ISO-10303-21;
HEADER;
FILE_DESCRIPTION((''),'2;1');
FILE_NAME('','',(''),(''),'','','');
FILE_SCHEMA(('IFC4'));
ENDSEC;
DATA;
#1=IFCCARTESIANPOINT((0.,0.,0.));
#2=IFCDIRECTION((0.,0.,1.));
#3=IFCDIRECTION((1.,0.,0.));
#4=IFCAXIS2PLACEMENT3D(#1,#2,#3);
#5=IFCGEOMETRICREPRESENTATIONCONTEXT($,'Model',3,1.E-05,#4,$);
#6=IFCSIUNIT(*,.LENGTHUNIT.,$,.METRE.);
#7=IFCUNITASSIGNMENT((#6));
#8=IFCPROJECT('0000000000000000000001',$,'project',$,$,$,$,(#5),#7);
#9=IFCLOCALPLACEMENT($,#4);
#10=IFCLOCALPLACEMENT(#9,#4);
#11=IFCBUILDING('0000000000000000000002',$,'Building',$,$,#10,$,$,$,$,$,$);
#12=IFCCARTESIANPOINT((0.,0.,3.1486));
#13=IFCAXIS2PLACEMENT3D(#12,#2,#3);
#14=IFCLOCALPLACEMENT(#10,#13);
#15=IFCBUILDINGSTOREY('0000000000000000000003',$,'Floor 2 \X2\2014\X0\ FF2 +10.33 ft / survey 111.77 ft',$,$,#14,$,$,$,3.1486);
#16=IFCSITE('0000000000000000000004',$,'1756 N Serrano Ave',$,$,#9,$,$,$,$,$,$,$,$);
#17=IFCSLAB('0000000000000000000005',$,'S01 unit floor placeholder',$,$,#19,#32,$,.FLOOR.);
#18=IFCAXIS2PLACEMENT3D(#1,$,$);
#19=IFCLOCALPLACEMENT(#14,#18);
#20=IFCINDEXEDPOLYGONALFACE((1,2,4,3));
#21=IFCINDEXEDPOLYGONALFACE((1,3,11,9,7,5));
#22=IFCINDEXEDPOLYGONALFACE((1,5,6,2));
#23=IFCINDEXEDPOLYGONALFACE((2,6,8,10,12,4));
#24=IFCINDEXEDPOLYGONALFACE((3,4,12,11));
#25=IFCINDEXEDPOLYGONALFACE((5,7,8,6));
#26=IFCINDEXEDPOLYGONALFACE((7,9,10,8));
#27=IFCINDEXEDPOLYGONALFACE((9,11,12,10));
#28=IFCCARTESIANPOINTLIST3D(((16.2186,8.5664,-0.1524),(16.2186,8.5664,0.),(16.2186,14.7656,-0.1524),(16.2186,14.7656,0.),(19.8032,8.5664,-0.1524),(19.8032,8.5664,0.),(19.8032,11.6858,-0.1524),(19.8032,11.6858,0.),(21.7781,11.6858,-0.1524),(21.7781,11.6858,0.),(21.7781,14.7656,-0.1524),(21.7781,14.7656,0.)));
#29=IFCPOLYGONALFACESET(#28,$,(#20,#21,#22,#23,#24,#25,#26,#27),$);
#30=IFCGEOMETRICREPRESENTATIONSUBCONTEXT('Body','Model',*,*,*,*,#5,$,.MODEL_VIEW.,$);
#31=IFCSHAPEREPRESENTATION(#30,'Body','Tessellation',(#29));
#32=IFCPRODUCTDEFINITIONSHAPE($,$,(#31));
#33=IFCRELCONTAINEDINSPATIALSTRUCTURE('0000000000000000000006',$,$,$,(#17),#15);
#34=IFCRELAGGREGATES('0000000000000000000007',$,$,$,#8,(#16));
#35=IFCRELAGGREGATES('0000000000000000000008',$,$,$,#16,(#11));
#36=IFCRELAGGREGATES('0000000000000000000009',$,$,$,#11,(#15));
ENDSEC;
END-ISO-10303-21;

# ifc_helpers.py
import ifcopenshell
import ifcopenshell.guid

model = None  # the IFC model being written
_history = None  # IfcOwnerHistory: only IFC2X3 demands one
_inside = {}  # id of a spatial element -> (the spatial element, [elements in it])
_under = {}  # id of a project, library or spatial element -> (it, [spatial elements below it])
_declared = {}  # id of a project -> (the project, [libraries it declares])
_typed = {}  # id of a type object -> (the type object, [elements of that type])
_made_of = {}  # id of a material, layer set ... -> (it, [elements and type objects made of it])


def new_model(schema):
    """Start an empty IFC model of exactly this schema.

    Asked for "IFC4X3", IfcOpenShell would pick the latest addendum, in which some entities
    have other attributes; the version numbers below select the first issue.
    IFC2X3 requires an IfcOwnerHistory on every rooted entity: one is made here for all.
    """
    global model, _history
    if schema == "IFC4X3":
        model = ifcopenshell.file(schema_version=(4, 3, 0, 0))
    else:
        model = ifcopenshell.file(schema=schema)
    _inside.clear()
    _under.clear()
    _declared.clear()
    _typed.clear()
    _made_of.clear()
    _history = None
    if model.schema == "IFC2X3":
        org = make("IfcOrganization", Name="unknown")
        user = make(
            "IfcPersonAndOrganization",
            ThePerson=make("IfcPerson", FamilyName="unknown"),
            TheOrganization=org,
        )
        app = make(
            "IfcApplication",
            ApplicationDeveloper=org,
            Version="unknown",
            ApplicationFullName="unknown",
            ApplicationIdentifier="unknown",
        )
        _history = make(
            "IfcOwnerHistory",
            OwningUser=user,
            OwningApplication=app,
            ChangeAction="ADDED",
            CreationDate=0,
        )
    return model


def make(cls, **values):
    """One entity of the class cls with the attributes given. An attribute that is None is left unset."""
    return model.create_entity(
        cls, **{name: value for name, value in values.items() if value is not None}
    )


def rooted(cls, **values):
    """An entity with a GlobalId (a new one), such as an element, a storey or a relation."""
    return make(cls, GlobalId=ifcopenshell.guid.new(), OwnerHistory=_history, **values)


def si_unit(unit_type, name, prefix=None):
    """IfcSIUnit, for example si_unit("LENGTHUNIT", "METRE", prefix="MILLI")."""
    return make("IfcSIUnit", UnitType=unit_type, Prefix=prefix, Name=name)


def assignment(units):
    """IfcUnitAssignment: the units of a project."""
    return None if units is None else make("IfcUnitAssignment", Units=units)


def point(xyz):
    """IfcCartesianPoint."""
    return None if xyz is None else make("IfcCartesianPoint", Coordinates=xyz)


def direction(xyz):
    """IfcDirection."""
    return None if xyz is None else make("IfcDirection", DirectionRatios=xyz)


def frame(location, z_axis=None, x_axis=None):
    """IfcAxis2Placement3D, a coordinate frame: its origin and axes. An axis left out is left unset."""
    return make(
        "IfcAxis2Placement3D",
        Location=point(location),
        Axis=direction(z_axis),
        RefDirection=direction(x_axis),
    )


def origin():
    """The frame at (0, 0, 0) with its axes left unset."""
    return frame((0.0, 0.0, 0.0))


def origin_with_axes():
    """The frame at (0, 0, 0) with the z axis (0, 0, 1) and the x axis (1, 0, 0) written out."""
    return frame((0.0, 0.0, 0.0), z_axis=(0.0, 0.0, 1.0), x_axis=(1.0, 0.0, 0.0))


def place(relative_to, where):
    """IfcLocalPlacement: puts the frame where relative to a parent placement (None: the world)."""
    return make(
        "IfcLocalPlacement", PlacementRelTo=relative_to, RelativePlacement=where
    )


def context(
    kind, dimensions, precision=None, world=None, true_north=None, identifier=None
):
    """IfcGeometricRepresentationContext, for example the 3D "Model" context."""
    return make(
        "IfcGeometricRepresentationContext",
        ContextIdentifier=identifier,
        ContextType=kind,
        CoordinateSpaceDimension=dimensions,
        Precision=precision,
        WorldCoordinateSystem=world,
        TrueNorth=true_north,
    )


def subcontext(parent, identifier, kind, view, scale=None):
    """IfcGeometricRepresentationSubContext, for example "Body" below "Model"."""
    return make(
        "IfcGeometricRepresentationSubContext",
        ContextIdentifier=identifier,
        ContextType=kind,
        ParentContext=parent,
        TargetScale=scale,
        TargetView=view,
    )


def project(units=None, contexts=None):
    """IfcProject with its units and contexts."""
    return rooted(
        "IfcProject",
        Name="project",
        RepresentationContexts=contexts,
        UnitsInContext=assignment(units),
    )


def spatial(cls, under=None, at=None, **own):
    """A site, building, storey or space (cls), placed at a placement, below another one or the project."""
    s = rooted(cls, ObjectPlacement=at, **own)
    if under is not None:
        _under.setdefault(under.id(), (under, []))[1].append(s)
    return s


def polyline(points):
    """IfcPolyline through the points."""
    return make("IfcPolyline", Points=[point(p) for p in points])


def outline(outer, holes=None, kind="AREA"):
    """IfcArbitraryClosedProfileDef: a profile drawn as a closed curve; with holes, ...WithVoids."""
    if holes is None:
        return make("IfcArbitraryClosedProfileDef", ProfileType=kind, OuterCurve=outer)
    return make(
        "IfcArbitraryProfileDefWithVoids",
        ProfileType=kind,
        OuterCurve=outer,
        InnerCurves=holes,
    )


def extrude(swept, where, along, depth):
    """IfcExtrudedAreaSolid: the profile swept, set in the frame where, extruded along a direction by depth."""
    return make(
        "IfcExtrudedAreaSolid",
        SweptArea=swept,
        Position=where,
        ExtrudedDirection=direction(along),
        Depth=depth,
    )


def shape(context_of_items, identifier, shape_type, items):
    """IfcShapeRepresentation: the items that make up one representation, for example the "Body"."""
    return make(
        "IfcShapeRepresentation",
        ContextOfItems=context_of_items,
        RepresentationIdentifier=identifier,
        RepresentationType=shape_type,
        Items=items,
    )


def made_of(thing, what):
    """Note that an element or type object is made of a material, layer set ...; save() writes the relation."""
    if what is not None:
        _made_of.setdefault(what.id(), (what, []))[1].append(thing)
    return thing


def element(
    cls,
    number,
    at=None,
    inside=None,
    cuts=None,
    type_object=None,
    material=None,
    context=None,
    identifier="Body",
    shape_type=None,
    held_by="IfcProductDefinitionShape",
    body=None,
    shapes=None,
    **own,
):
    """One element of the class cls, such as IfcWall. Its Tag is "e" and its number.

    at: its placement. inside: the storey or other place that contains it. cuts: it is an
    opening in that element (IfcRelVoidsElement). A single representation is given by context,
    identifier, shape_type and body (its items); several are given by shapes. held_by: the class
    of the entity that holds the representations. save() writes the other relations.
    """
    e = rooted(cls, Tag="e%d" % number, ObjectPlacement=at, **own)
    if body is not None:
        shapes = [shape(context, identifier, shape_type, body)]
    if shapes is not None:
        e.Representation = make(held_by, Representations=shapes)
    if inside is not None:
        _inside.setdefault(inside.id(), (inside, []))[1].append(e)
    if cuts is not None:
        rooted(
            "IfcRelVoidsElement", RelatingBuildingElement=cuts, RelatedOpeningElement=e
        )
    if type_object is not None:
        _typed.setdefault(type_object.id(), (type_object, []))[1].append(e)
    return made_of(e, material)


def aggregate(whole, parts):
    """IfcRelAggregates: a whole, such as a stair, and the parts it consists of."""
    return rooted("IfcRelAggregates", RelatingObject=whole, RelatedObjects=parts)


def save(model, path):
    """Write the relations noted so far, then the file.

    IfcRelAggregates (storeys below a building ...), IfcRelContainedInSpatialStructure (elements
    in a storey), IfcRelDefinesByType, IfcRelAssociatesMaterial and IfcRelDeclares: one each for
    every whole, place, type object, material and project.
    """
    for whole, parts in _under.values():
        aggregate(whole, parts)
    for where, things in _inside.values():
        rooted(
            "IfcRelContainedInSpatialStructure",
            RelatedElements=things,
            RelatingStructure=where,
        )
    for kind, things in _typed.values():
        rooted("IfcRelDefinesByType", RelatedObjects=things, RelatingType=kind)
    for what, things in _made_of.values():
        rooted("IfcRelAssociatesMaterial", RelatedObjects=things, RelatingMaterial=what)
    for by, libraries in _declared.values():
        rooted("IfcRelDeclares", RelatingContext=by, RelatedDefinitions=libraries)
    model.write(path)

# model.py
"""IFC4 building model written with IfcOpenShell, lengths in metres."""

from ifc_helpers import new_model, si_unit, frame, origin, origin_with_axes, place, context, subcontext, project, spatial, polyline, outline, extrude, element, save


model = new_model("IFC4")

# Units and contexts
model_context = context("Model", 3, precision=1e-05, world=origin_with_axes())
body_context = subcontext(model_context, "Body", "Model", "MODEL_VIEW")
ifc_project = project(units=[si_unit("LENGTHUNIT", "METRE")], contexts=[model_context])

# Site, building, storey
site_placement = place(None, origin_with_axes())
site = spatial("IfcSite", under=ifc_project, at=site_placement, Name="1756 N Serrano Ave")
building_placement = place(site_placement, origin_with_axes())
building = spatial("IfcBuilding", under=site, at=building_placement, Name="Building")
storey_placement = place(building_placement, frame((0.0, 0.0, 3.1486), z_axis=(0.0, 0.0, 1.0), x_axis=(1.0, 0.0, 0.0)))
storey = spatial("IfcBuildingStorey", under=building, at=storey_placement, Name="Floor 2 — FF2 +10.33 ft / survey 111.77 ft", Elevation=3.1486)

# Slab
slab_placement = place(storey_placement, frame((0.0, 0.0, -0.1524), z_axis=(0.0, 0.0, 1.0), x_axis=(1.0, 0.0, 0.0)))
element("IfcSlab", 1, at=slab_placement, inside=storey, Name="S01 unit floor placeholder", PredefinedType="FLOOR", context=body_context, shape_type="SweptSolid", body=[
    extrude(outline(polyline([(16.2186, 8.5664), (19.8032, 8.5664), (19.8032, 11.6858), (21.7781, 11.6858), (21.7781, 14.7656), (16.2186, 14.7656), (16.2186, 8.5664)])), origin(), (0.0, 0.0, 1.0), 0.1524),
])

save(model, "model.ifc")
